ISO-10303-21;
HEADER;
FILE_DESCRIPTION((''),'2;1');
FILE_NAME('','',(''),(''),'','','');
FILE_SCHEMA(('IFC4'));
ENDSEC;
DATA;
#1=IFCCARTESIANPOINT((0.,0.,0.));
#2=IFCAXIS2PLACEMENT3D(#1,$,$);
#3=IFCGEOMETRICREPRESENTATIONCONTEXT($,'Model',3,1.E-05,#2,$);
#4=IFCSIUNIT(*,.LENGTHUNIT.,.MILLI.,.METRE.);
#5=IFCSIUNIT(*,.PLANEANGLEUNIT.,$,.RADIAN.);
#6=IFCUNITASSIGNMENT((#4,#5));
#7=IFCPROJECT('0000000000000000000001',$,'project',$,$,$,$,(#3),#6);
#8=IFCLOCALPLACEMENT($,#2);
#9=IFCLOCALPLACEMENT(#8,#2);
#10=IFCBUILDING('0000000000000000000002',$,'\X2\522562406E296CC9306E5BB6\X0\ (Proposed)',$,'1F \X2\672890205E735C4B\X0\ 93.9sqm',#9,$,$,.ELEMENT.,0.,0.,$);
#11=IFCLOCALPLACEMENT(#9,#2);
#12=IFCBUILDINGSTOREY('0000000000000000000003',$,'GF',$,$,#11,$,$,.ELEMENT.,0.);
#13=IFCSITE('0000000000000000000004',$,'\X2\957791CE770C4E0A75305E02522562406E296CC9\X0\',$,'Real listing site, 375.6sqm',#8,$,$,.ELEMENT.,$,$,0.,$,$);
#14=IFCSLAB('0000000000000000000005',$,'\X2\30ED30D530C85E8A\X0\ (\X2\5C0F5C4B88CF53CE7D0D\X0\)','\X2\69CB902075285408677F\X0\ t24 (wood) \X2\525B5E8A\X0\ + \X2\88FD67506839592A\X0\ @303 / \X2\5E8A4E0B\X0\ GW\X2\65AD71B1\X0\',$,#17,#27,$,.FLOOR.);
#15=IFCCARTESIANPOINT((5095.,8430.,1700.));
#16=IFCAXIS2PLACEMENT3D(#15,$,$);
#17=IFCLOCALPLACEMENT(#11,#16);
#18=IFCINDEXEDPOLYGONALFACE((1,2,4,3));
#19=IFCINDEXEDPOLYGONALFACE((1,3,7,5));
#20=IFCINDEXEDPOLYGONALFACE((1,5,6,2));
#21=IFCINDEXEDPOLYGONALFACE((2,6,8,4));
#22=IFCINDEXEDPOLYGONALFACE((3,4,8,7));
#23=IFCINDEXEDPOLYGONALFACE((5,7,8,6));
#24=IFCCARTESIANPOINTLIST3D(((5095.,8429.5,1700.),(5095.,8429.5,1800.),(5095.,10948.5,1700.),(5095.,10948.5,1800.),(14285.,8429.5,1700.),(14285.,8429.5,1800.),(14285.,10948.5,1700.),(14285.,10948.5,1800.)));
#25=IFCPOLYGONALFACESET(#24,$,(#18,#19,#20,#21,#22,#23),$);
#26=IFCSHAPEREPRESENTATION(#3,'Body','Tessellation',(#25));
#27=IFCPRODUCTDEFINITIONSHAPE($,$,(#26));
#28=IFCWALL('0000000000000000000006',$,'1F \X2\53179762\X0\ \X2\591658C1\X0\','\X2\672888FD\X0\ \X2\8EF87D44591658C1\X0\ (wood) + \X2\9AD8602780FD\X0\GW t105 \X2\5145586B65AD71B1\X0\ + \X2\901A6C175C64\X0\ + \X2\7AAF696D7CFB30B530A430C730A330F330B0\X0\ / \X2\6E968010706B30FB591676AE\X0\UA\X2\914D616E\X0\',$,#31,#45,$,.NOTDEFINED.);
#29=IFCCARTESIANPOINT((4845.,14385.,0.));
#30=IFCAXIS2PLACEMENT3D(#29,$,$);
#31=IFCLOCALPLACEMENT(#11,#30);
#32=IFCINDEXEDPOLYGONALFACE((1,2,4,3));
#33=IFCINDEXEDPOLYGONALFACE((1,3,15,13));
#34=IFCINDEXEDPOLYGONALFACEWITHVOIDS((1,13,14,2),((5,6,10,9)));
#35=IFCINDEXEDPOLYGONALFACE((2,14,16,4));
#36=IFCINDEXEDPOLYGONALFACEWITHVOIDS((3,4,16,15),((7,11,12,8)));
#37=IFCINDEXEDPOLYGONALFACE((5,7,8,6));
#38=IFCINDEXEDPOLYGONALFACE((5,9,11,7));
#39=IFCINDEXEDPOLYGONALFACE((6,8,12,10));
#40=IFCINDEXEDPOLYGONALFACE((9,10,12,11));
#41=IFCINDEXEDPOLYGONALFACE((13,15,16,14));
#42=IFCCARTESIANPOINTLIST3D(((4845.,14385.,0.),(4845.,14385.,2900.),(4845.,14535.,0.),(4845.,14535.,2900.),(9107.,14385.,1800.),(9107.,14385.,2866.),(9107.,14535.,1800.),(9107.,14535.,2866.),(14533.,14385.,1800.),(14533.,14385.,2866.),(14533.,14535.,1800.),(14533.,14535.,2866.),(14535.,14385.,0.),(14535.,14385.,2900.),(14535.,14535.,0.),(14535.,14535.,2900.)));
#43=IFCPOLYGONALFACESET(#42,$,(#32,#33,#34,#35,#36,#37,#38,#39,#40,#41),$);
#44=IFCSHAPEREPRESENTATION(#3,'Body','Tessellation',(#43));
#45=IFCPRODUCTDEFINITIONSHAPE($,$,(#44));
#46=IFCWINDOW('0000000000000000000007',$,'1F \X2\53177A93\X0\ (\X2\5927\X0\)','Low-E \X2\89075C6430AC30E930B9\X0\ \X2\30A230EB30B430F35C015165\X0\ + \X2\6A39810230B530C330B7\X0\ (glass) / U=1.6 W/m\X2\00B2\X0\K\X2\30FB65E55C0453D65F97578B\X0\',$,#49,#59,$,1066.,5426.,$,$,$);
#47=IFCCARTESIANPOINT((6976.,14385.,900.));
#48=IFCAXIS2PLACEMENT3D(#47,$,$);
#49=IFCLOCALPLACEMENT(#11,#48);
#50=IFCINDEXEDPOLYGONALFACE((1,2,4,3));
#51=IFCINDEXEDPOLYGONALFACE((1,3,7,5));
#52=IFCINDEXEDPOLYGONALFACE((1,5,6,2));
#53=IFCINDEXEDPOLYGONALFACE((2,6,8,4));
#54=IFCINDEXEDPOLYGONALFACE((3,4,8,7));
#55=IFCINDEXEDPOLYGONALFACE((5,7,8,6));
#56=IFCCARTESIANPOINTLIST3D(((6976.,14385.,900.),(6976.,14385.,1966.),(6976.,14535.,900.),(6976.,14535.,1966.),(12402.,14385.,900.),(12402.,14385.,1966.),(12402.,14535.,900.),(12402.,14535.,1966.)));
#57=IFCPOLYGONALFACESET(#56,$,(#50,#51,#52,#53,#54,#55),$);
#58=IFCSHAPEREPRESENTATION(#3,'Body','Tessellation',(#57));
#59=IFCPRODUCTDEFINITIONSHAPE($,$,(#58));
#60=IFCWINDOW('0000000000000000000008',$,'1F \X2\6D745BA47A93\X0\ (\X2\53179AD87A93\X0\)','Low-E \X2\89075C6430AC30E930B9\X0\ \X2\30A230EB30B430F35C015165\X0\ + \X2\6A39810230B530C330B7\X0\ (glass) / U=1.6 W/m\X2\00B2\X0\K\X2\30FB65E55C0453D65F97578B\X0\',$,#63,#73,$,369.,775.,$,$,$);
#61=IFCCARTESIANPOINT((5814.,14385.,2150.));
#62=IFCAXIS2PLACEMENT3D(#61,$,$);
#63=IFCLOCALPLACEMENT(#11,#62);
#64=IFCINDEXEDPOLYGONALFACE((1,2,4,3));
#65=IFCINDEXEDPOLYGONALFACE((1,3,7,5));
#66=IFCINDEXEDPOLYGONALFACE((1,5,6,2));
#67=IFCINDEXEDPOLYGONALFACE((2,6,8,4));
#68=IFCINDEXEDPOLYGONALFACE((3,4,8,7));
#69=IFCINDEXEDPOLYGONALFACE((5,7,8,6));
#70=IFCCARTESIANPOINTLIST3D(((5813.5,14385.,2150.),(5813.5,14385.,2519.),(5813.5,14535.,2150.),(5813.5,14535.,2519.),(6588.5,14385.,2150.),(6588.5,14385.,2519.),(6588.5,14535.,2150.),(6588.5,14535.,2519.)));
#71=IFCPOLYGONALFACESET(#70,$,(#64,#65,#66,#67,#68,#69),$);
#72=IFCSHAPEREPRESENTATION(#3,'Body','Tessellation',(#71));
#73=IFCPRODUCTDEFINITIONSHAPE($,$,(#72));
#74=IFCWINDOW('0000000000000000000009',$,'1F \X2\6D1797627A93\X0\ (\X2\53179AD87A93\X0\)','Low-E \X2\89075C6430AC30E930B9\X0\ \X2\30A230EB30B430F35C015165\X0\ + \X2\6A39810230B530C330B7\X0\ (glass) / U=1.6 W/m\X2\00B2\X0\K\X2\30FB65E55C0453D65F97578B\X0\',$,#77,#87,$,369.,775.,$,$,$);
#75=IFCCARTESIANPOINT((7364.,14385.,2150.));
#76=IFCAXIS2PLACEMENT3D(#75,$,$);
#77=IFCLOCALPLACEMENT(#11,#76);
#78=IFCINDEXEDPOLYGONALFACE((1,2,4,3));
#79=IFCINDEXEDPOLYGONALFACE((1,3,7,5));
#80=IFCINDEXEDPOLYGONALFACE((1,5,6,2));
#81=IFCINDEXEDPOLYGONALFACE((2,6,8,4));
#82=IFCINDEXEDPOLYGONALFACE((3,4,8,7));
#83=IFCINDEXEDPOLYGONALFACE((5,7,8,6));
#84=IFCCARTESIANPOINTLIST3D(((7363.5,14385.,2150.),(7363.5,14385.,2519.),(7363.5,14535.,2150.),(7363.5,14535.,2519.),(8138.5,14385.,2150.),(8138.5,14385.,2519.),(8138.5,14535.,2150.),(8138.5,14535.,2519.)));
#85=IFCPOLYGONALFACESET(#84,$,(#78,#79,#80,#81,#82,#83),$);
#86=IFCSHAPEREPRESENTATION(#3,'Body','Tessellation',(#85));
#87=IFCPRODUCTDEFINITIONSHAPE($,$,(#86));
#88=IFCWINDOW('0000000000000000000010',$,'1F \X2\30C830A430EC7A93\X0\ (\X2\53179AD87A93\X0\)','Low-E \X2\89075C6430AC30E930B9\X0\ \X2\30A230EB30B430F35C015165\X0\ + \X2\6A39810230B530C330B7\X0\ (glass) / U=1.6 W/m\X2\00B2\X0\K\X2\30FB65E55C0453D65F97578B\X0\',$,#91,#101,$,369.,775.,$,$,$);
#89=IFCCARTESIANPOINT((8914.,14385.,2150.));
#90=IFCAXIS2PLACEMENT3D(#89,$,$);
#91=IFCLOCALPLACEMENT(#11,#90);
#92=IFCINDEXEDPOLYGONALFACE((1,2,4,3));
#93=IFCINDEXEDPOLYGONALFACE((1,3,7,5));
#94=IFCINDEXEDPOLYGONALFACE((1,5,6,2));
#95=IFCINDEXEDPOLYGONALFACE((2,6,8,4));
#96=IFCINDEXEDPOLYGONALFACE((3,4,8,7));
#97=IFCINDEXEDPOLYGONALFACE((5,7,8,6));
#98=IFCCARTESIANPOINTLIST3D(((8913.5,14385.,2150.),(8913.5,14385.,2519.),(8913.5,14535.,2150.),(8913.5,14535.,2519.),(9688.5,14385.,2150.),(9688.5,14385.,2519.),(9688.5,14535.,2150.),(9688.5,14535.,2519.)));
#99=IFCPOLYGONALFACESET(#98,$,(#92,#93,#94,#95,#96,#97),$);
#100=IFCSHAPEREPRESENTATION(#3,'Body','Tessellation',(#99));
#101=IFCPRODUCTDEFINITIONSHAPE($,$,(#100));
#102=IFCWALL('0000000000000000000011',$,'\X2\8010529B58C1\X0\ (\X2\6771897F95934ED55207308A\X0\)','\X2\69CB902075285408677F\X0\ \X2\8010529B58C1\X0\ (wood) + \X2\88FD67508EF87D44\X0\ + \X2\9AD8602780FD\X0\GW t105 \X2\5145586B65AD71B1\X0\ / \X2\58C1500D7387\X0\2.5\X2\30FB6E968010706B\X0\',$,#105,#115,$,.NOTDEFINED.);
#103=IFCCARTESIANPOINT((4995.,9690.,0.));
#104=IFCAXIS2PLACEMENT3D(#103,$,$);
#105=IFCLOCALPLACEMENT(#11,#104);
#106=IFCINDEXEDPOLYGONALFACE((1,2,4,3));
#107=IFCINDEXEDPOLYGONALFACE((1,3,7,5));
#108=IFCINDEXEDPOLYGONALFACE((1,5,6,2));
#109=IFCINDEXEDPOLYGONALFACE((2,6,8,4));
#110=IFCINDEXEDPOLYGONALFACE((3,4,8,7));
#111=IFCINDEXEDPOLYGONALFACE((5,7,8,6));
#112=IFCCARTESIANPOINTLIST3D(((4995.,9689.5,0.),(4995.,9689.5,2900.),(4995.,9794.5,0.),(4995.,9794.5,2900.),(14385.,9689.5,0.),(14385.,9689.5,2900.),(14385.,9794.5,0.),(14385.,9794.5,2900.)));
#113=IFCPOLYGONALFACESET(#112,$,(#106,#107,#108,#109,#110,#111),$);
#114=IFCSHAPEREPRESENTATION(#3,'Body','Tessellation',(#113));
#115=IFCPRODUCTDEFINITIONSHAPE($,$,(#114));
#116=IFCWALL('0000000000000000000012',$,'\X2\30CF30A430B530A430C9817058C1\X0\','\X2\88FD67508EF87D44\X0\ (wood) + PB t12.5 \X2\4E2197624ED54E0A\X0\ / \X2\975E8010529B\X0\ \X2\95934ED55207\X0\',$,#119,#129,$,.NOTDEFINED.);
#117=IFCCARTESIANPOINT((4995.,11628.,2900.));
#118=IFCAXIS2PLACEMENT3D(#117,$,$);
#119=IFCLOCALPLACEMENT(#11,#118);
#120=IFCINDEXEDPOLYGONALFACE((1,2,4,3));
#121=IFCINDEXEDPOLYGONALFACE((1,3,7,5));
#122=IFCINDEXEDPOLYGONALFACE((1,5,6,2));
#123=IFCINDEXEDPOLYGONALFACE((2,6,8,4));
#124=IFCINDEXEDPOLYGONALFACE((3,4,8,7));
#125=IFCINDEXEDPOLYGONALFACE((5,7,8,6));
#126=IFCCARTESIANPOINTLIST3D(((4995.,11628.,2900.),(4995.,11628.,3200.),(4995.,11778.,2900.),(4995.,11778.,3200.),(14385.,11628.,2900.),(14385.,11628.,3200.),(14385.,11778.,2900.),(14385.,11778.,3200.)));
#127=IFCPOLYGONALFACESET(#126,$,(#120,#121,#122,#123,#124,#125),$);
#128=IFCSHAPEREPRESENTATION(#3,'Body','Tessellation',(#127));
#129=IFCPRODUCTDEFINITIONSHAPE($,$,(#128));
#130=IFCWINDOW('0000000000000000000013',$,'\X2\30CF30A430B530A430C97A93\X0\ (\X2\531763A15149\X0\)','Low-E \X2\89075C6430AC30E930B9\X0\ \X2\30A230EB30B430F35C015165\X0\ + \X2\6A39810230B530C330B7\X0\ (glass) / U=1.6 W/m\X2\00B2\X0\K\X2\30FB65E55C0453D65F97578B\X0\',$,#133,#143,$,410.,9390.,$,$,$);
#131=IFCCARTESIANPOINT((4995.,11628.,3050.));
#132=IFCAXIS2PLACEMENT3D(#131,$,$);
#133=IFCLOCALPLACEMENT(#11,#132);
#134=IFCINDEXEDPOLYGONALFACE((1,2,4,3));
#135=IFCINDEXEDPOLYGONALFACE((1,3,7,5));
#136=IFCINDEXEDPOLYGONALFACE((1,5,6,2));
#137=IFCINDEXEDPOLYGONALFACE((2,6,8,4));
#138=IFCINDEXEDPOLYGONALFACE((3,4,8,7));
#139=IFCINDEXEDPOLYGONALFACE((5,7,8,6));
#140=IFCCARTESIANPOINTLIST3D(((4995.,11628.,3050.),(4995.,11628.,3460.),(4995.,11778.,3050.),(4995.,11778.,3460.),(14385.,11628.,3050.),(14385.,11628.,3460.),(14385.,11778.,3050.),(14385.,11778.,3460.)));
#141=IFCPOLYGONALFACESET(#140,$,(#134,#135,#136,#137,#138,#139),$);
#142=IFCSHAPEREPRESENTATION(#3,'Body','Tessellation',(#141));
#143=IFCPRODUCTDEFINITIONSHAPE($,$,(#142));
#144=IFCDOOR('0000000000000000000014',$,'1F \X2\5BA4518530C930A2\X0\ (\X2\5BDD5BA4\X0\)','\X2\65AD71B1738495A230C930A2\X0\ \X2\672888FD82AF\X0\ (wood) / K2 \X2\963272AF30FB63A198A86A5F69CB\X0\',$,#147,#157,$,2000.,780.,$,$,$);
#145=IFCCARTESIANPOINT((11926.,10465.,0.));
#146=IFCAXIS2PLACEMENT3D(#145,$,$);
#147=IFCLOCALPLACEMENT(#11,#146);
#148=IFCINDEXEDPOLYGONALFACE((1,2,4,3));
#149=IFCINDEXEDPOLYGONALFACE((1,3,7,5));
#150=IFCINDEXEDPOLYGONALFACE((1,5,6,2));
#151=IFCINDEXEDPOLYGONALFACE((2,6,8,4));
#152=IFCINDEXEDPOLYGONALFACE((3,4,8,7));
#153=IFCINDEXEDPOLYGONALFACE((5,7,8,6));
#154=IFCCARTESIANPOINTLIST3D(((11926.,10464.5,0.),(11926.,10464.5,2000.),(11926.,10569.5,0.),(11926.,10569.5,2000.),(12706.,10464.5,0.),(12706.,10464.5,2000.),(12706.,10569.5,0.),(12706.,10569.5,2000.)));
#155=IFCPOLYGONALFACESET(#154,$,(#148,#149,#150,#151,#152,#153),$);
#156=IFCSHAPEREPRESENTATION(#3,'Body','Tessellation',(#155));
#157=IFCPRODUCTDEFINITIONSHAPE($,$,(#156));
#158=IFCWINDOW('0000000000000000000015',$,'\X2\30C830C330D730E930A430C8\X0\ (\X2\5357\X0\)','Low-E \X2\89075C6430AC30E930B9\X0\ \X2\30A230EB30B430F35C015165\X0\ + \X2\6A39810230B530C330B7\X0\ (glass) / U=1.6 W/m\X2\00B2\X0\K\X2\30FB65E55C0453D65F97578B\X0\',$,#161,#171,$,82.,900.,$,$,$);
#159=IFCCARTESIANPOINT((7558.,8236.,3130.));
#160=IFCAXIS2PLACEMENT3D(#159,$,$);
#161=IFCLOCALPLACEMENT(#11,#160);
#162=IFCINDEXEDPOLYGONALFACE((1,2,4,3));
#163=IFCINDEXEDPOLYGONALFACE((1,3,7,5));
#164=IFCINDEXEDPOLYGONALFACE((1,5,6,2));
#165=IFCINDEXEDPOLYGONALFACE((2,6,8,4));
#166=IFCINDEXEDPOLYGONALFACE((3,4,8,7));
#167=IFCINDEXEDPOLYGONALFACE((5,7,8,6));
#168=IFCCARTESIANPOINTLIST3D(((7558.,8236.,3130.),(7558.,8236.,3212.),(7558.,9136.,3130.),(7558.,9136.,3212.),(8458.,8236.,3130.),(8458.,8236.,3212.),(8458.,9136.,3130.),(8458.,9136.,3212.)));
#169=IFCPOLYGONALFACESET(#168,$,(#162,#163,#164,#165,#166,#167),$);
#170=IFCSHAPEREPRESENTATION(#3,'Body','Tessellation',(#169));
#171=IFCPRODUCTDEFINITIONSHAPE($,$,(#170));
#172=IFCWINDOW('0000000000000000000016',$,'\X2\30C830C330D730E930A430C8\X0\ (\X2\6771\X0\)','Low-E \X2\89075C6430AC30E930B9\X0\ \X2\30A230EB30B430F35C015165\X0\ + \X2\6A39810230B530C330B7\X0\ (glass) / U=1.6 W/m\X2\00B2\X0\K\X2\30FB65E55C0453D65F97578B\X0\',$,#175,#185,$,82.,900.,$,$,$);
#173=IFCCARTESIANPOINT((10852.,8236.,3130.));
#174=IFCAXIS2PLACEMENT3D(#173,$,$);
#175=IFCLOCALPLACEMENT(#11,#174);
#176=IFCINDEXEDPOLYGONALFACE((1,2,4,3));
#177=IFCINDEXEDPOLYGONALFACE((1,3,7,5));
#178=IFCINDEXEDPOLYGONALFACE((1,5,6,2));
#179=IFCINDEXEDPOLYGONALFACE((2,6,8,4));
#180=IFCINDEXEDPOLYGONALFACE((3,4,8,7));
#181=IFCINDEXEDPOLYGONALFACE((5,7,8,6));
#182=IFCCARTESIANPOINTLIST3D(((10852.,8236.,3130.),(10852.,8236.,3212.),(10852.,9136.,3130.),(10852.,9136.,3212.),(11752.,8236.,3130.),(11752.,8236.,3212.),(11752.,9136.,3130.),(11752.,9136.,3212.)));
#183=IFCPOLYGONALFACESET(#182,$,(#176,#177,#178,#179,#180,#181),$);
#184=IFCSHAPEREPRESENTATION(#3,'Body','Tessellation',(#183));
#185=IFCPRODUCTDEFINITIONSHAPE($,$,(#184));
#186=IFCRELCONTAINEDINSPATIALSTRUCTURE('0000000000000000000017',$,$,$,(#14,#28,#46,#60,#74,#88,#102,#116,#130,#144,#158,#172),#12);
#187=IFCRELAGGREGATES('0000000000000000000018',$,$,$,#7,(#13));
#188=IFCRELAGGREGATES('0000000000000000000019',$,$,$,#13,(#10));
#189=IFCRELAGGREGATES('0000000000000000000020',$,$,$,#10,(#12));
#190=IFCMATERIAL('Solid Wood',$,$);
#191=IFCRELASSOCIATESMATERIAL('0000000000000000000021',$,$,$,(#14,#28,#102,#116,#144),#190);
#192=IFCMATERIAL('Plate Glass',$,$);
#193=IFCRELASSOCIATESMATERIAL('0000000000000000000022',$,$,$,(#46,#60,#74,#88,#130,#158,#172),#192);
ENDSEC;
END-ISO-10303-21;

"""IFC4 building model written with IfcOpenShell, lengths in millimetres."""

from ifc_helpers import new_model, si_unit, frame, frame_2d, origin, place, context, project, spatial, rectangle, extrude, material, element, fill, save


model = new_model("IFC4")

# Units and contexts
model_context = context("Model", 3, precision=1e-05, world=origin())
ifc_project = project(units=[si_unit("LENGTHUNIT", "METRE", prefix="MILLI"), si_unit("PLANEANGLEUNIT", "RADIAN")], contexts=[model_context])

# Site, building, storey
site_placement = place(None, origin())
site = spatial("IfcSite", under=ifc_project, at=site_placement, Name="長野県上田市別所温泉", ObjectType="Real listing site, 375.6sqm", CompositionType="ELEMENT", RefElevation=0.0)
building_placement = place(site_placement, origin())
building = spatial("IfcBuilding", under=site, at=building_placement, Name="別所温泉の家 (Proposed)", ObjectType="1F 木造平屋 93.9sqm", CompositionType="ELEMENT", ElevationOfRefHeight=0.0, ElevationOfTerrain=0.0)
storey_placement = place(building_placement, origin())
storey = spatial("IfcBuildingStorey", under=building, at=storey_placement, Name="GF", CompositionType="ELEMENT", Elevation=0.0)

# Slab
ifc_material_1 = material(Name="Solid Wood")
slab_placement = place(storey_placement, frame((5095.0, 8430.0, 1700.0)))
element("IfcSlab", 1, at=slab_placement, inside=storey, material=ifc_material_1, Name="ロフト床 (小屋裏収納)", Description="構造用合板 t24 (wood) 剛床 + 製材根太 @303 / 床下 GW断熱", PredefinedType="FLOOR", context=model_context, shape_type="SweptSolid", body=[
    extrude(rectangle(XDim=9190.0, YDim=2519.0, at=frame_2d((4595.0, 1259.0))), frame((5095.0, 8430.0, 1700.0)), (0.0, 0.0, 1.0), 100.0),
])

# Wall, openings, windows
wall_1_placement = place(storey_placement, frame((4845.0, 14385.0, 0.0)))
wall_1 = element("IfcWall", 2, at=wall_1_placement, inside=storey, material=ifc_material_1, Name="1F 北面 外壁", Description="木製 軸組外壁 (wood) + 高性能GW t105 充填断熱 + 通気層 + 窯業系サイディング / 準耐火・外皮UA配慮", PredefinedType="NOTDEFINED", context=model_context, shape_type="SweptSolid", body=[
    extrude(rectangle(XDim=9690.0, YDim=150.0, at=frame_2d((4845.0, 75.0))), frame((4845.0, 14385.0, 0.0)), (0.0, 0.0, 1.0), 2900.0),
])
opening_1_placement = place(storey_placement, frame((6976.0, 14385.0, 900.0)))
opening_1 = element("IfcOpeningElement", 3, at=opening_1_placement, cuts=wall_1, PredefinedType="NOTDEFINED", context=model_context, shape_type="SweptSolid", body=[
    extrude(rectangle(XDim=5426.0, YDim=150.0, at=frame_2d((2713.0, 75.0))), frame((6976.0, 14385.0, 900.0)), (0.0, 0.0, 1.0), 1066.0),
])
opening_2_placement = place(storey_placement, frame((5814.0, 14385.0, 2150.0)))
opening_2 = element("IfcOpeningElement", 4, at=opening_2_placement, cuts=wall_1, PredefinedType="NOTDEFINED", context=model_context, shape_type="SweptSolid", body=[
    extrude(rectangle(XDim=775.0, YDim=150.0, at=frame_2d((387.0, 75.0))), frame((5814.0, 14385.0, 2150.0)), (0.0, 0.0, 1.0), 369.0),
])
opening_3_placement = place(storey_placement, frame((7364.0, 14385.0, 2150.0)))
opening_3 = element("IfcOpeningElement", 5, at=opening_3_placement, cuts=wall_1, PredefinedType="NOTDEFINED", context=model_context, shape_type="SweptSolid", body=[
    extrude(rectangle(XDim=775.0, YDim=150.0, at=frame_2d((387.0, 75.0))), frame((7364.0, 14385.0, 2150.0)), (0.0, 0.0, 1.0), 369.0),
])
opening_4_placement = place(storey_placement, frame((8914.0, 14385.0, 2150.0)))
opening_4 = element("IfcOpeningElement", 6, at=opening_4_placement, cuts=wall_1, PredefinedType="NOTDEFINED", context=model_context, shape_type="SweptSolid", body=[
    extrude(rectangle(XDim=775.0, YDim=150.0, at=frame_2d((387.0, 75.0))), frame((8914.0, 14385.0, 2150.0)), (0.0, 0.0, 1.0), 369.0),
])
ifc_material_2 = material(Name="Plate Glass")
window_1_placement = place(storey_placement, frame((6976.0, 14385.0, 900.0)))
window_1 = element("IfcWindow", 7, at=window_1_placement, inside=storey, material=ifc_material_2, Name="1F 北窓 (大)", Description="Low-E 複層ガラス アルゴン封入 + 樹脂サッシ (glass) / U=1.6 W/m²K・日射取得型", OverallHeight=1066.0, OverallWidth=5426.0, context=model_context, shape_type="SweptSolid", body=[
    extrude(rectangle(XDim=5426.0, YDim=150.0, at=frame_2d((2713.0, 75.0))), frame((6976.0, 14385.0, 900.0)), (0.0, 0.0, 1.0), 1066.0),
])
fill(opening_1, window_1)
window_2_placement = place(storey_placement, frame((5814.0, 14385.0, 2150.0)))
window_2 = element("IfcWindow", 8, at=window_2_placement, inside=storey, material=ifc_material_2, Name="1F 浴室窓 (北高窓)", Description="Low-E 複層ガラス アルゴン封入 + 樹脂サッシ (glass) / U=1.6 W/m²K・日射取得型", OverallHeight=369.0, OverallWidth=775.0, context=model_context, shape_type="SweptSolid", body=[
    extrude(rectangle(XDim=775.0, YDim=150.0, at=frame_2d((387.0, 75.0))), frame((5814.0, 14385.0, 2150.0)), (0.0, 0.0, 1.0), 369.0),
])
fill(opening_2, window_2)
window_3_placement = place(storey_placement, frame((7364.0, 14385.0, 2150.0)))
window_3 = element("IfcWindow", 9, at=window_3_placement, inside=storey, material=ifc_material_2, Name="1F 洗面窓 (北高窓)", Description="Low-E 複層ガラス アルゴン封入 + 樹脂サッシ (glass) / U=1.6 W/m²K・日射取得型", OverallHeight=369.0, OverallWidth=775.0, context=model_context, shape_type="SweptSolid", body=[
    extrude(rectangle(XDim=775.0, YDim=150.0, at=frame_2d((387.0, 75.0))), frame((7364.0, 14385.0, 2150.0)), (0.0, 0.0, 1.0), 369.0),
])
fill(opening_3, window_3)
window_4_placement = place(storey_placement, frame((8914.0, 14385.0, 2150.0)))
window_4 = element("IfcWindow", 10, at=window_4_placement, inside=storey, material=ifc_material_2, Name="1F トイレ窓 (北高窓)", Description="Low-E 複層ガラス アルゴン封入 + 樹脂サッシ (glass) / U=1.6 W/m²K・日射取得型", OverallHeight=369.0, OverallWidth=775.0, context=model_context, shape_type="SweptSolid", body=[
    extrude(rectangle(XDim=775.0, YDim=150.0, at=frame_2d((387.0, 75.0))), frame((8914.0, 14385.0, 2150.0)), (0.0, 0.0, 1.0), 369.0),
])
fill(opening_4, window_4)

# Wall
wall_2_placement = place(storey_placement, frame((4995.0, 9690.0, 0.0)))
element("IfcWall", 11, at=wall_2_placement, inside=storey, material=ifc_material_1, Name="耐力壁 (東西間仕切り)", Description="構造用合板 耐力壁 (wood) + 製材軸組 + 高性能GW t105 充填断熱 / 壁倍率2.5・準耐火", PredefinedType="NOTDEFINED", context=model_context, shape_type="SweptSolid", body=[
    extrude(rectangle(XDim=9390.0, YDim=105.0, at=frame_2d((4695.0, 52.0))), frame((4995.0, 9690.0, 0.0)), (0.0, 0.0, 1.0), 2900.0),
])

# Wall, opening, window
wall_3_placement = place(storey_placement, frame((4995.0, 11628.0, 2900.0)))
wall_3 = element("IfcWall", 12, at=wall_3_placement, inside=storey, material=ifc_material_1, Name="ハイサイド腰壁", Description="製材軸組 (wood) + PB t12.5 両面仕上 / 非耐力 間仕切", PredefinedType="NOTDEFINED", context=model_context, shape_type="SweptSolid", body=[
    extrude(rectangle(XDim=9390.0, YDim=150.0, at=frame_2d((4695.0, 75.0))), frame((4995.0, 11628.0, 2900.0)), (0.0, 0.0, 1.0), 700.0),
])
opening_5_placement = place(storey_placement, frame((4995.0, 11628.0, 3050.0)))
opening_5 = element("IfcOpeningElement", 13, at=opening_5_placement, cuts=wall_3, PredefinedType="NOTDEFINED", context=model_context, shape_type="SweptSolid", body=[
    extrude(rectangle(XDim=9390.0, YDim=150.0, at=frame_2d((4695.0, 75.0))), frame((4995.0, 11628.0, 3050.0)), (0.0, 0.0, 1.0), 410.0),
])
window_5_placement = place(storey_placement, frame((4995.0, 11628.0, 3050.0)))
window_5 = element("IfcWindow", 14, at=window_5_placement, inside=storey, material=ifc_material_2, Name="ハイサイド窓 (北採光)", Description="Low-E 複層ガラス アルゴン封入 + 樹脂サッシ (glass) / U=1.6 W/m²K・日射取得型", OverallHeight=410.0, OverallWidth=9390.0, context=model_context, shape_type="SweptSolid", body=[
    extrude(rectangle(XDim=9390.0, YDim=150.0, at=frame_2d((4695.0, 75.0))), frame((4995.0, 11628.0, 3050.0)), (0.0, 0.0, 1.0), 410.0),
])
fill(opening_5, window_5)

# Door
door_1_placement = place(storey_placement, frame((11926.0, 10465.0, 0.0)))
element("IfcDoor", 15, at=door_1_placement, inside=storey, material=ifc_material_1, Name="1F 室内ドア (寝室)", Description="断熱玄関ドア 木製芯 (wood) / K2 防犯・採風機構", OverallHeight=2000.0, OverallWidth=780.0, context=model_context, shape_type="SweptSolid", body=[
    extrude(rectangle(XDim=780.0, YDim=105.0, at=frame_2d((390.0, 52.0))), frame((11926.0, 10465.0, 0.0)), (0.0, 0.0, 1.0), 2000.0),
])

# Windows
window_6_placement = place(storey_placement, frame((7558.0, 8236.0, 3130.0)))
element("IfcWindow", 16, at=window_6_placement, inside=storey, material=ifc_material_2, Name="トップライト (南)", Description="Low-E 複層ガラス アルゴン封入 + 樹脂サッシ (glass) / U=1.6 W/m²K・日射取得型", OverallHeight=82.0, OverallWidth=900.0, context=model_context, shape_type="SweptSolid", body=[
    extrude(rectangle(XDim=900.0, YDim=900.0, at=frame_2d((450.0, 450.0))), frame((7558.0, 8236.0, 3130.0)), (0.0, 0.0, 1.0), 82.0),
])
window_7_placement = place(storey_placement, frame((10852.0, 8236.0, 3130.0)))
element("IfcWindow", 17, at=window_7_placement, inside=storey, material=ifc_material_2, Name="トップライト (東)", Description="Low-E 複層ガラス アルゴン封入 + 樹脂サッシ (glass) / U=1.6 W/m²K・日射取得型", OverallHeight=82.0, OverallWidth=900.0, context=model_context, shape_type="SweptSolid", body=[
    extrude(rectangle(XDim=900.0, YDim=900.0, at=frame_2d((450.0, 450.0))), frame((10852.0, 8236.0, 3130.0)), (0.0, 0.0, 1.0), 82.0),
])

save(model, "model.ifc")
